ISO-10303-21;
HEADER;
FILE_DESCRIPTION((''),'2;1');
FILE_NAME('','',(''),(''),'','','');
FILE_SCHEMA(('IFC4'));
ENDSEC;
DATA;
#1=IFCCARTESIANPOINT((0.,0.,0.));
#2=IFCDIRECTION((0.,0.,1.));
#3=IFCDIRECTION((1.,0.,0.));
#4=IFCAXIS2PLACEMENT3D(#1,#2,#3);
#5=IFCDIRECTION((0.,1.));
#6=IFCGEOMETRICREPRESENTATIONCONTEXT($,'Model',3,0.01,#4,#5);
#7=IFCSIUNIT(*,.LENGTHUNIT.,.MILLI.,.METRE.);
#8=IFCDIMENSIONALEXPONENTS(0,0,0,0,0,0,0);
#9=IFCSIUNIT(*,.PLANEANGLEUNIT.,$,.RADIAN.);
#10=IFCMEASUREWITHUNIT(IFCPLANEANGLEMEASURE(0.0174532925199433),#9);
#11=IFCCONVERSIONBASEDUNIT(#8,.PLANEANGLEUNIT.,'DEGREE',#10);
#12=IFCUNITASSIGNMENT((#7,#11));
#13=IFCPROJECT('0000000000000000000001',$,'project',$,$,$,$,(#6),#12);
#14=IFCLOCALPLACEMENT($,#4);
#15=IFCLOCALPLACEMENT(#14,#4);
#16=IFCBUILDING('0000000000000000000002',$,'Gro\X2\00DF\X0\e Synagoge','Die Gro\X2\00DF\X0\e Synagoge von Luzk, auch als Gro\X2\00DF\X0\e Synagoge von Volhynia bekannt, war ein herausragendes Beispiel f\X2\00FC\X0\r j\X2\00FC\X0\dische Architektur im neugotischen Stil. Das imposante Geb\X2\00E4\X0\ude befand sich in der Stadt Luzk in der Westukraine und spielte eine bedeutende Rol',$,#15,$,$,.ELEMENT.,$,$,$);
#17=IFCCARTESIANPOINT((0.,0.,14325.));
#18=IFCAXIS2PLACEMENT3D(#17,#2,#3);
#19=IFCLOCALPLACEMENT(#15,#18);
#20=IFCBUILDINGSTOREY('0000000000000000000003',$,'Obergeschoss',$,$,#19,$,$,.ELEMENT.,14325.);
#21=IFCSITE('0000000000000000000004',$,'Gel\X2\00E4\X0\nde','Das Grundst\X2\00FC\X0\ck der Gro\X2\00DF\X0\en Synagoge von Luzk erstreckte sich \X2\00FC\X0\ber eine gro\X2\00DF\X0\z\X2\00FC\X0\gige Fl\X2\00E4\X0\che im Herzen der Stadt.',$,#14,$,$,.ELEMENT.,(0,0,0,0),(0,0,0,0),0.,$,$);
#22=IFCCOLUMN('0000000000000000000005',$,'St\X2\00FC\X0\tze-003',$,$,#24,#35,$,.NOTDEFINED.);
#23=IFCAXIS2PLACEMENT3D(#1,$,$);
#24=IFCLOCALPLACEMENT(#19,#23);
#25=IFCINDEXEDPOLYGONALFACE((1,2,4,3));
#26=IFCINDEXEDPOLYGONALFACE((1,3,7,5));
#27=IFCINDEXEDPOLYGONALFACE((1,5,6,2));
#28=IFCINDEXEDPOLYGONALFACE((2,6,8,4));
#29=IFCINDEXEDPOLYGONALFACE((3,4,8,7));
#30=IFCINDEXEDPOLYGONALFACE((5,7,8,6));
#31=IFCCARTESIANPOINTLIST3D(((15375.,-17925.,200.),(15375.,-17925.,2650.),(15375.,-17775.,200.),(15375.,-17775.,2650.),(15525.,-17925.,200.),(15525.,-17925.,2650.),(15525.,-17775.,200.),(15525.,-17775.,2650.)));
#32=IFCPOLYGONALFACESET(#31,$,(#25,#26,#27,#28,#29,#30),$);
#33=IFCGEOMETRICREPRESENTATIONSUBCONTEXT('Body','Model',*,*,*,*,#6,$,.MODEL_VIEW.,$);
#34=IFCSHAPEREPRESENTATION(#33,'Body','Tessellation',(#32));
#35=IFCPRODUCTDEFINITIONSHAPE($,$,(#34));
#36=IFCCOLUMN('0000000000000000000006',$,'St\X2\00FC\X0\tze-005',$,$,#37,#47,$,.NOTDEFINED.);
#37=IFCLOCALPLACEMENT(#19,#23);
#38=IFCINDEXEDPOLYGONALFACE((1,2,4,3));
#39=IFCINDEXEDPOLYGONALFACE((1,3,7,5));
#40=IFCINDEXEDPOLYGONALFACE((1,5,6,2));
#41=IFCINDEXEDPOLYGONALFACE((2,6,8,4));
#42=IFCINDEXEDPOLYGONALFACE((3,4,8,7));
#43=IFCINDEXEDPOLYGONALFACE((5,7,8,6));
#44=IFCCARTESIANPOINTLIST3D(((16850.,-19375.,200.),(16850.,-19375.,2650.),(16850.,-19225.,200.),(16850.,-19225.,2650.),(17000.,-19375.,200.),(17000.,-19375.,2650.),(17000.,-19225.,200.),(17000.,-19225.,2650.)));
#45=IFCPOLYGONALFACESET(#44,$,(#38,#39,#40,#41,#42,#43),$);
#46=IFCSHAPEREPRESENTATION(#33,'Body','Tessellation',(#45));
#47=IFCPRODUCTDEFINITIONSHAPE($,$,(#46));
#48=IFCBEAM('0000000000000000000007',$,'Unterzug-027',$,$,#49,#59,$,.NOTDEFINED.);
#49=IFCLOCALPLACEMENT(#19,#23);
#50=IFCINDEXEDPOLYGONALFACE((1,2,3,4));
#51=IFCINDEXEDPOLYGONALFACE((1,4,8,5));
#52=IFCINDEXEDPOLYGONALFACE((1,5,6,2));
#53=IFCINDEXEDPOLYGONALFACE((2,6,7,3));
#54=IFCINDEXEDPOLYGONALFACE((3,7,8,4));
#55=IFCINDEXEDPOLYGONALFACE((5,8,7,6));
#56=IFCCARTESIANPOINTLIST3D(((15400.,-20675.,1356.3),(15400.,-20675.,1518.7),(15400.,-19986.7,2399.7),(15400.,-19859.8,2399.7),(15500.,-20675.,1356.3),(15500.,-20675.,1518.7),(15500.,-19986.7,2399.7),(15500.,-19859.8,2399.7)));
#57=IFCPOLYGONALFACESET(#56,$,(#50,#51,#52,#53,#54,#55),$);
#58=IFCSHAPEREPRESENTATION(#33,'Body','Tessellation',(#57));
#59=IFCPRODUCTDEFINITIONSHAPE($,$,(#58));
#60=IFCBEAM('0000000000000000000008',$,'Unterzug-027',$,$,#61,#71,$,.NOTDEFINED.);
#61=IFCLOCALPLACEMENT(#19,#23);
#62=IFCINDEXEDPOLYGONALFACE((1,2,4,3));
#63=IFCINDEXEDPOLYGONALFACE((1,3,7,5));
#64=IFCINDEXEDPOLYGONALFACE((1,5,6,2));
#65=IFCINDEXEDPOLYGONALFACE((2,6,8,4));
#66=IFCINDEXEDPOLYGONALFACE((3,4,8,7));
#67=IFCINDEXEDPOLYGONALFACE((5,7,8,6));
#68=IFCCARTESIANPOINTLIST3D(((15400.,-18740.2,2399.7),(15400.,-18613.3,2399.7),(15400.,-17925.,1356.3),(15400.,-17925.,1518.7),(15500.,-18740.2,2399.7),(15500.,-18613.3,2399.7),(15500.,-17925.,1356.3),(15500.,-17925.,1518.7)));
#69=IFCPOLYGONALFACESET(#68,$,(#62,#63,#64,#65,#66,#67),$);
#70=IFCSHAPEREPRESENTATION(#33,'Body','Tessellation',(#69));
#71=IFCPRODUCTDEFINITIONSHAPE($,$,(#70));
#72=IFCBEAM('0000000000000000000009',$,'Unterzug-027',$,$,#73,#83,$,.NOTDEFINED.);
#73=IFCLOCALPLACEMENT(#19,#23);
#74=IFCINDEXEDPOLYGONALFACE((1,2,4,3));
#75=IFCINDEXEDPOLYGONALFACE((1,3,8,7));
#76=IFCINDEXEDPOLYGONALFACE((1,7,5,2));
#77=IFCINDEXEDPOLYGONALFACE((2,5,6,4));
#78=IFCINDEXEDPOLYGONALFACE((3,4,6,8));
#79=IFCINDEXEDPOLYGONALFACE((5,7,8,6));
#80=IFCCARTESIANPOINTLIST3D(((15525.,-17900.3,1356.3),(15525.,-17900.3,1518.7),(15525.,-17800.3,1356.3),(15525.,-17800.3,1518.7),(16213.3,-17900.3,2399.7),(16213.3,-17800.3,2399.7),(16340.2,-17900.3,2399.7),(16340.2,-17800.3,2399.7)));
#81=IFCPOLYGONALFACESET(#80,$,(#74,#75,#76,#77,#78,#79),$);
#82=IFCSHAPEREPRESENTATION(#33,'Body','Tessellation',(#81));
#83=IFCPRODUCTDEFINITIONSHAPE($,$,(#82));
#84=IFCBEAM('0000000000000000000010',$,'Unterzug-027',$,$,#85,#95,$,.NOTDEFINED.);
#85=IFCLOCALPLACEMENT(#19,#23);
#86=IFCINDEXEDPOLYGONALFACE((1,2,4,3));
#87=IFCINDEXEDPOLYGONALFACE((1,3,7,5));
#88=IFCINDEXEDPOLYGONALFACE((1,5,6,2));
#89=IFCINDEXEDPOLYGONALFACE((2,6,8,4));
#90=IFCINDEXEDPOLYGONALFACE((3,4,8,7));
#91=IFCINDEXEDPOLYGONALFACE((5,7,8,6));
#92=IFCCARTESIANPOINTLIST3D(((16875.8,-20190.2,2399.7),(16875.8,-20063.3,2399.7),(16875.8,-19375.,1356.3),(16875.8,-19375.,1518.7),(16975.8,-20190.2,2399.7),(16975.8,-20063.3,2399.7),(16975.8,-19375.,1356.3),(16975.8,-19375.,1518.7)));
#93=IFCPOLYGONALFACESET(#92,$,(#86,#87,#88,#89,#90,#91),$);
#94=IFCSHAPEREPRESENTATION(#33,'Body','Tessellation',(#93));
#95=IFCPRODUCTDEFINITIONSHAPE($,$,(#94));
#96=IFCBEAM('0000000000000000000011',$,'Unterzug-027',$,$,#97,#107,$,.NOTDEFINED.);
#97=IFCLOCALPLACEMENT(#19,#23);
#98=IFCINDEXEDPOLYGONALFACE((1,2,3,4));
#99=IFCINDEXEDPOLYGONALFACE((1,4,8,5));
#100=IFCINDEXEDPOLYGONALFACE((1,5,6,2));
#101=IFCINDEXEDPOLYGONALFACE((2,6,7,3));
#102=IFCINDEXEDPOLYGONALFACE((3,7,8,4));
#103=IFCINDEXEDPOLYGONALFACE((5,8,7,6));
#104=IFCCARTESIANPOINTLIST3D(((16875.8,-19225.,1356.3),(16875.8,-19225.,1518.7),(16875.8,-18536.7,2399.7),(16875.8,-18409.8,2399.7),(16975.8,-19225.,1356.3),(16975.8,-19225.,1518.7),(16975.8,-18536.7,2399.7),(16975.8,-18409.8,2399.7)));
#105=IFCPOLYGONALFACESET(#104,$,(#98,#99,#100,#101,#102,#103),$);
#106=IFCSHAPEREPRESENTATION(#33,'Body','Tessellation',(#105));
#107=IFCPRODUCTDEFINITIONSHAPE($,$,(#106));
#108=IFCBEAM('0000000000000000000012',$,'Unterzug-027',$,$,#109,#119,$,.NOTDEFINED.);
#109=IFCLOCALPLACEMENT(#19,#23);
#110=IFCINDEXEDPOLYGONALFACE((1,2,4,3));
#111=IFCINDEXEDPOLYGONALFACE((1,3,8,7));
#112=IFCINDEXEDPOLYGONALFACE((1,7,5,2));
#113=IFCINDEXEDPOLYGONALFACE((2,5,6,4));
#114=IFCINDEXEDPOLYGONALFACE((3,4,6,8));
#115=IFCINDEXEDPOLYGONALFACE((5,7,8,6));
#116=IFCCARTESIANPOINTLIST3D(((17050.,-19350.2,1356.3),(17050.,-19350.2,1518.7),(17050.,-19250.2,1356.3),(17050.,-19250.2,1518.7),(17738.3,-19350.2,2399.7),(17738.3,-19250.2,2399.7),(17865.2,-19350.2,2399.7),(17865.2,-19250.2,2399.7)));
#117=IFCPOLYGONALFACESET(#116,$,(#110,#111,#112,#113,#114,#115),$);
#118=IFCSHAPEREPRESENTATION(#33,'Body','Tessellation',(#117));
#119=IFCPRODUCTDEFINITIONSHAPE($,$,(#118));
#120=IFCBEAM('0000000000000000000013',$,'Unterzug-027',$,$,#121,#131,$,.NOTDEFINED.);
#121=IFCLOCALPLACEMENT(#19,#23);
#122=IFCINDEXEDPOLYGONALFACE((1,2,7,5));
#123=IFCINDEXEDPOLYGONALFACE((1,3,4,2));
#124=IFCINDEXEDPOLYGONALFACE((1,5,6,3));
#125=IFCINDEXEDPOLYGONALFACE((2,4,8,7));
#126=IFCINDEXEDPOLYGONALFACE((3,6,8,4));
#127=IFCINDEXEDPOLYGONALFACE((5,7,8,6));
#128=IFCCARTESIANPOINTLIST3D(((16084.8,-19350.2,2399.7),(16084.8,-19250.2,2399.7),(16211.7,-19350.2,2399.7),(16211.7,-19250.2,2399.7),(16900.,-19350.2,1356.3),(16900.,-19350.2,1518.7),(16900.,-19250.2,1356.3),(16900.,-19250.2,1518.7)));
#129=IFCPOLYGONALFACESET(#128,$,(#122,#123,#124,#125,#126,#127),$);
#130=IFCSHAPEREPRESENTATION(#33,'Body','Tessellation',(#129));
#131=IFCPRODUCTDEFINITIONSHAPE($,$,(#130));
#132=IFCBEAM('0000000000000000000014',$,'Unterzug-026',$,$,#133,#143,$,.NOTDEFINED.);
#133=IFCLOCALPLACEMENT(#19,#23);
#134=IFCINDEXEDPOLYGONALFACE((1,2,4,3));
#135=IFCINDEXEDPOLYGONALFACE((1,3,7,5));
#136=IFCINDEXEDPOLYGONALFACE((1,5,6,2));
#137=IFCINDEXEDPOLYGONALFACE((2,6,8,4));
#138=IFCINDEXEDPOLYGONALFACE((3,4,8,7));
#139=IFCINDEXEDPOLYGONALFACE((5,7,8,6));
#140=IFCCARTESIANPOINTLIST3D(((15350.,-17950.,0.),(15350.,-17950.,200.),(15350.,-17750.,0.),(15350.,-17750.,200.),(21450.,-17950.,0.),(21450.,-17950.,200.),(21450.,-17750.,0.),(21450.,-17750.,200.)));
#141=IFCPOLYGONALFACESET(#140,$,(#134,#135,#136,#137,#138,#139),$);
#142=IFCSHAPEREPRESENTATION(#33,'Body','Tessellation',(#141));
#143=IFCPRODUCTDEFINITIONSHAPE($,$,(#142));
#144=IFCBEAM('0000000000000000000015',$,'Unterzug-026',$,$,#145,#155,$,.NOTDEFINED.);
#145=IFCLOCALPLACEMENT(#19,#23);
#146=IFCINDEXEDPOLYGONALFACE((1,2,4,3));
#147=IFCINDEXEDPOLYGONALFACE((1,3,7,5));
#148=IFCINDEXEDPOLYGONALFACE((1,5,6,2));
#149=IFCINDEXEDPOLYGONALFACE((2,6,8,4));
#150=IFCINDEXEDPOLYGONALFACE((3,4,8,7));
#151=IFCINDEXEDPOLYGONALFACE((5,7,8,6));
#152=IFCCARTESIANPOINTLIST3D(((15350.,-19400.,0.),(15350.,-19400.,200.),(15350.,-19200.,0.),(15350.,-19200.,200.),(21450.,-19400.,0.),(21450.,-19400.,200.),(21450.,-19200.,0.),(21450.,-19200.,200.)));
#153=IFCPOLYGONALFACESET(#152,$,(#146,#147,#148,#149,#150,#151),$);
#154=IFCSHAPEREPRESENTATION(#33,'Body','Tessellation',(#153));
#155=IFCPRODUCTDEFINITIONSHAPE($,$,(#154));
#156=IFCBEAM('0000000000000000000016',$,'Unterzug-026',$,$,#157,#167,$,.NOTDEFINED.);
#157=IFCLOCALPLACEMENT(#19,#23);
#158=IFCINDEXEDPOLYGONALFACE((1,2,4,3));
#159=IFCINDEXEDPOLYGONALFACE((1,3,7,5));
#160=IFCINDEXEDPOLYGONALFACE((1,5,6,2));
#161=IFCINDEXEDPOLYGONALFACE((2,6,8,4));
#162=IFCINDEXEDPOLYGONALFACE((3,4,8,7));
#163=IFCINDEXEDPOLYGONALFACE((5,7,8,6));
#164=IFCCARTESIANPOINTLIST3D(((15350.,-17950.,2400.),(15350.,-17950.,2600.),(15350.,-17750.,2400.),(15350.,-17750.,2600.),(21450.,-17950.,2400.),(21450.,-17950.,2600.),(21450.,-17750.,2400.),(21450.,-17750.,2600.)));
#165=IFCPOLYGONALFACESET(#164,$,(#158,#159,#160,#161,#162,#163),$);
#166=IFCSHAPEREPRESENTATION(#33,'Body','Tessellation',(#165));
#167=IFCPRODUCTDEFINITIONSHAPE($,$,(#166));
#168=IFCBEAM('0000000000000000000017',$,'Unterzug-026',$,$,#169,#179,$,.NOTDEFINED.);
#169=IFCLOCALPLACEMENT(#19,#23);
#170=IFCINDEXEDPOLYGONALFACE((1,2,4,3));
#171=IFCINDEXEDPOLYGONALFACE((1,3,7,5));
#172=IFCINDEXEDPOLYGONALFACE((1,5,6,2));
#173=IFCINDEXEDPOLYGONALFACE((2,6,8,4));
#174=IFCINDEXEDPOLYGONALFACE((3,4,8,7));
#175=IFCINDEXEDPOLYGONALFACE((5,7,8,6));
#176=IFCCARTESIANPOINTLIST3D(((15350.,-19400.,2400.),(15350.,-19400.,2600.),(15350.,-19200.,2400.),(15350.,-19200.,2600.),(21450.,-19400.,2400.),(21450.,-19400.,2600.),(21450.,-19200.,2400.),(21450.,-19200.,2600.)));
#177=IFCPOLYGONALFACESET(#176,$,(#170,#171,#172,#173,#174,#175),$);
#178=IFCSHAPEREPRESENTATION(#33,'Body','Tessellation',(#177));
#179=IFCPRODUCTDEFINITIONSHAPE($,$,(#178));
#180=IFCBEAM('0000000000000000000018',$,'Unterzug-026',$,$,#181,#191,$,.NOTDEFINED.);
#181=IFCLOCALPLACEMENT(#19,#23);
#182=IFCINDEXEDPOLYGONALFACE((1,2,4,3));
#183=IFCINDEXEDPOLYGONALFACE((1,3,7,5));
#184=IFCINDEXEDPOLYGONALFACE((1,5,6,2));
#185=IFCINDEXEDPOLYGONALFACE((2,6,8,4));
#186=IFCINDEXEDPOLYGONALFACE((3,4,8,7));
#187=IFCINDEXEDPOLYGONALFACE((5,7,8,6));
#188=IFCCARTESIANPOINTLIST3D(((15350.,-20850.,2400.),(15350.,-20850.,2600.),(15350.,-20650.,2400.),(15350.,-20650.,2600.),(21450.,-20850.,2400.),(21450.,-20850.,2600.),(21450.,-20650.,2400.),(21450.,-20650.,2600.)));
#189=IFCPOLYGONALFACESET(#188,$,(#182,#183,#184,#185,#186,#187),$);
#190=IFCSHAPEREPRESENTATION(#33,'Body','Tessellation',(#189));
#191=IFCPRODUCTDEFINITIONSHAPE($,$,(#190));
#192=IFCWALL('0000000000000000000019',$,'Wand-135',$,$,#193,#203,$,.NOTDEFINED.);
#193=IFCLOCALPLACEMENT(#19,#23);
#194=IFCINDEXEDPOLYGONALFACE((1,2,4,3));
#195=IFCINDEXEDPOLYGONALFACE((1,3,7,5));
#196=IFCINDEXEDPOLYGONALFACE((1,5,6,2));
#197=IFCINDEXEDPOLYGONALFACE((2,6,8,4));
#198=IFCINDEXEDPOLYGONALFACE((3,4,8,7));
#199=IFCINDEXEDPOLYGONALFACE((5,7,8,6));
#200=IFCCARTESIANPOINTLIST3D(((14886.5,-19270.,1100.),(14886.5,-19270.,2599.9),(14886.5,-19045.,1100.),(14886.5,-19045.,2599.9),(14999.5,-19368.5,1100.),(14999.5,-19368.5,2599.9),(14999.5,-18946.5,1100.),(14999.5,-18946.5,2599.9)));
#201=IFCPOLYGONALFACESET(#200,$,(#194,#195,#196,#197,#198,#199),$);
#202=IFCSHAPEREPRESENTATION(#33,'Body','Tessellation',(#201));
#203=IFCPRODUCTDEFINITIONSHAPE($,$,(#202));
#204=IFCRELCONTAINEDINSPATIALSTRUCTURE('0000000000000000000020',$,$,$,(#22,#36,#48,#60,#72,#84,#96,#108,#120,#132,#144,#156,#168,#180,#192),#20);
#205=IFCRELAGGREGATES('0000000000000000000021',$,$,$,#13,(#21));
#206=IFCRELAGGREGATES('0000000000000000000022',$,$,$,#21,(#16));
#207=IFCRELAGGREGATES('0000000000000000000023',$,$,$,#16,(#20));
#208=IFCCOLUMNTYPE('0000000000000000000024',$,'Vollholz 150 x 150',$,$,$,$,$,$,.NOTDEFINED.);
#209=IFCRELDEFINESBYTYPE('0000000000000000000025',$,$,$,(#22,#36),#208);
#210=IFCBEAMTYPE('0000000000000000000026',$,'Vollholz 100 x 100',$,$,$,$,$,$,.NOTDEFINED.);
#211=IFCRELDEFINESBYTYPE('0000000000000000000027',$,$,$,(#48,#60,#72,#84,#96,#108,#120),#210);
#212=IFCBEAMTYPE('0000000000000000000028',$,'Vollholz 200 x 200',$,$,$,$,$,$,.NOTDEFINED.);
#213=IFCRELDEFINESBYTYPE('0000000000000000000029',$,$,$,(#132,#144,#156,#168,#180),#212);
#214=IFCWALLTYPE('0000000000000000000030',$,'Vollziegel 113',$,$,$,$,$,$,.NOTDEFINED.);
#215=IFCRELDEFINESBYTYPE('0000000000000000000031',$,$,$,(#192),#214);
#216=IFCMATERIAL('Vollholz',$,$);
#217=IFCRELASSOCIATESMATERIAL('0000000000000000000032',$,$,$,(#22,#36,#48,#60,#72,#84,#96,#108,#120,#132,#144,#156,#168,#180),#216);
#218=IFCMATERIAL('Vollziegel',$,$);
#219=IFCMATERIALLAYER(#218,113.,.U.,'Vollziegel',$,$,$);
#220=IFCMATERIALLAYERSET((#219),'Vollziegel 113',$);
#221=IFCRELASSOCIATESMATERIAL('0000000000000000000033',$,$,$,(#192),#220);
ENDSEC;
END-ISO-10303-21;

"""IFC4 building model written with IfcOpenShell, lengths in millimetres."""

from ifc_helpers import new_model, entity, si_unit, converted_unit, direction, frame, frame_2d, origin_with_axes, origin_2d_with_axis, place, context, subcontext, project, spatial, line, indexed_curve, rectangle, outline, extrude, clip, halfspace, material, layer, layer_set, layer_usage, type_object, element, save


model = new_model("IFC4")

# Units and contexts
model_context = context("Model", 3, precision=0.01, world=origin_with_axes(), true_north=direction((0.0, 1.0)))
body_context = subcontext(model_context, "Body", "Model", "MODEL_VIEW")
ifc_project = project(units=[si_unit("LENGTHUNIT", "METRE", prefix="MILLI"), converted_unit("PLANEANGLEUNIT", "DEGREE", entity("IfcPlaneAngleMeasure", 0.0174532925199433), si_unit("PLANEANGLEUNIT", "RADIAN"), dimensions=[0, 0, 0, 0, 0, 0, 0])], contexts=[model_context])

# Site, building, storey
site_placement = place(None, origin_with_axes())
site = spatial("IfcSite", under=ifc_project, at=site_placement, Name="Gelände", Description="Das Grundstück der Großen Synagoge von Luzk erstreckte sich über eine großzügige Fläche im Herzen der Stadt.", CompositionType="ELEMENT", RefLatitude=(0, 0, 0, 0), RefLongitude=(0, 0, 0, 0), RefElevation=0.0)
building_placement = place(site_placement, origin_with_axes())
building = spatial("IfcBuilding", under=site, at=building_placement, Name="Große Synagoge", Description="Die Große Synagoge von Luzk, auch als Große Synagoge von Volhynia bekannt, war ein herausragendes Beispiel für jüdische Architektur im neugotischen Stil. Das imposante Gebäude befand sich in der Stadt Luzk in der Westukraine und spielte eine bedeutende Rol", CompositionType="ELEMENT")
storey_placement = place(building_placement, frame((0.0, 0.0, 14325.0), z_axis=(0.0, 0.0, 1.0), x_axis=(1.0, 0.0, 0.0)))
storey = spatial("IfcBuildingStorey", under=building, at=storey_placement, Name="Obergeschoss", CompositionType="ELEMENT", Elevation=14325.0)

# Columns
ifc_material_1 = material(Name="Vollholz")
column_type = type_object("IfcColumnType", Name="Vollholz 150 x 150", PredefinedType="NOTDEFINED")
for number, where, z_axis, x_axis, name in (
    (1, (15450.0, -17850.0, 200.0), (0.0, 0.0, 1.0), (1.0, 0.0, 0.0), "Stütze-003"),
    (2, (16925.0, -19300.0, 200.0), (0.0, 0.0, 1.0), (1.0, 0.0, 0.0), "Stütze-005"),
):
    element("IfcColumn", number, at=place(storey_placement, frame(where, z_axis=z_axis, x_axis=x_axis)), inside=storey, type_object=column_type, material=ifc_material_1, Name=name, PredefinedType="NOTDEFINED", context=body_context, shape_type="SweptSolid", body=[
        extrude(rectangle(XDim=150.0, YDim=150.0, at=origin_2d_with_axis()), origin_with_axes(), (0.0, 0.0, 1.0), 2450.0),
    ])

# Beams
beam_type_1 = type_object("IfcBeamType", Name="Vollholz 100 x 100", PredefinedType="NOTDEFINED")
for number, where, z_axis, x_axis, name in (
    (3, (15450.0, -20675.0, 1518.7), (0.0, 0.0, 1.0), (1.0, 0.0, 0.0), "Unterzug-027"),
    (4, (15450.0, -17925.0, 1518.7), (0.0, 0.0, 1.0), (-1.0, 0.0, 0.0), "Unterzug-027"),
):
    element("IfcBeam", number, at=place(storey_placement, frame(where, z_axis=z_axis, x_axis=x_axis)), inside=storey, type_object=beam_type_1, material=ifc_material_1, Name=name, PredefinedType="NOTDEFINED", context=body_context, shape_type="Clipping", body=[
        clip(clip(extrude(rectangle(XDim=100.0, YDim=100.0, at=frame_2d((-50.0, 0.0), x_axis=(1.0, 0.0))), frame((0.0, -111.4, -142.6), z_axis=(0.0, 0.615661, 0.788011), x_axis=(0.0, -0.788011, 0.615661)), (0.0, 0.0, 1.0), 1409.5), halfspace(frame((0.0, 0.0, 0.0), z_axis=(0.0, 1.0, 0.0), x_axis=(0.0, 0.0, 1.0)), True)), halfspace(frame((0.0, 0.0, 881.0), z_axis=(0.0, 0.0, -1.0), x_axis=(0.0, 1.0, 0.0)), True)),
    ])
for number, where, z_axis, x_axis, name in (
    (5, (15525.0, -17850.3, 1518.7), (0.0, 0.0, 1.0), (0.0, -1.0, 0.0), "Unterzug-027"),
    (6, (16925.8, -19375.0, 1518.7), (0.0, 0.0, 1.0), (-1.0, 0.0, 0.0), "Unterzug-027"),
    (7, (16925.8, -19225.0, 1518.7), (0.0, 0.0, 1.0), (1.0, 0.0, 0.0), "Unterzug-027"),
):
    element("IfcBeam", number, at=place(storey_placement, frame(where, z_axis=z_axis, x_axis=x_axis)), inside=storey, type_object=beam_type_1, material=ifc_material_1, Name=name, PredefinedType="NOTDEFINED", context=body_context, shape_type="Clipping", body=[
        clip(clip(extrude(rectangle(XDim=100.0, YDim=100.0, at=frame_2d((-50.0, 0.0), x_axis=(1.0, 0.0))), frame((0.0, -111.4, -142.6), z_axis=(0.0, 0.615661, 0.788011), x_axis=(0.0, -0.788011, 0.615661)), (0.0, 0.0, 1.0), 1409.5), halfspace(frame((0.0, 0.0, 0.0), z_axis=(0.0, 1.0, 0.0), x_axis=(0.0, 0.0, 1.0)), True)), halfspace(frame((0.0, 0.0, 881.0), z_axis=(0.0, 0.0, -1.0), x_axis=(0.0, 1.0, 0.0)), True)),
    ])
for number, where, z_axis, x_axis, name in (
    (8, (17050.0, -19300.2, 1518.7), (0.0, 0.0, 1.0), (0.0, -1.0, 0.0), "Unterzug-027"),
    (9, (16900.0, -19300.2, 1518.7), (0.0, 0.0, 1.0), (0.0, 1.0, 0.0), "Unterzug-027"),
):
    element("IfcBeam", number, at=place(storey_placement, frame(where, z_axis=z_axis, x_axis=x_axis)), inside=storey, type_object=beam_type_1, material=ifc_material_1, Name=name, PredefinedType="NOTDEFINED", context=body_context, shape_type="Clipping", body=[
        clip(clip(extrude(rectangle(XDim=100.0, YDim=100.0, at=frame_2d((-50.0, 0.0), x_axis=(1.0, 0.0))), frame((0.0, -111.4, -142.6), z_axis=(0.0, 0.615661, 0.788011), x_axis=(0.0, -0.788011, 0.615661)), (0.0, 0.0, 1.0), 1409.5), halfspace(frame((0.0, 0.0, 0.0), z_axis=(0.0, 1.0, 0.0), x_axis=(0.0, 0.0, 1.0)), True)), halfspace(frame((0.0, 0.0, 881.0), z_axis=(0.0, 0.0, -1.0), x_axis=(0.0, 1.0, 0.0)), True)),
    ])
beam_type_2 = type_object("IfcBeamType", Name="Vollholz 200 x 200", PredefinedType="NOTDEFINED")
for number, where, z_axis, x_axis, name in (
    (10, (15350.0, -17850.0, 200.0), (0.0, 0.0, 1.0), (0.0, -1.0, 0.0), "Unterzug-026"),
    (11, (15350.0, -19300.0, 200.0), (0.0, 0.0, 1.0), (0.0, -1.0, 0.0), "Unterzug-026"),
    (12, (15350.0, -17850.0, 2600.0), (0.0, 0.0, 1.0), (0.0, -1.0, 0.0), "Unterzug-026"),
    (13, (15350.0, -19300.0, 2600.0), (0.0, 0.0, 1.0), (0.0, -1.0, 0.0), "Unterzug-026"),
    (14, (15350.0, -20750.0, 2600.0), (0.0, 0.0, 1.0), (0.0, -1.0, 0.0), "Unterzug-026"),
):
    element("IfcBeam", number, at=place(storey_placement, frame(where, z_axis=z_axis, x_axis=x_axis)), inside=storey, type_object=beam_type_2, material=ifc_material_1, Name=name, PredefinedType="NOTDEFINED", context=body_context, shape_type="SweptSolid", body=[
        extrude(rectangle(XDim=200.0, YDim=200.0, at=frame_2d((-100.0, 0.0), x_axis=(1.0, 0.0))), frame((0.0, 0.0, 0.0), z_axis=(0.0, 1.0, 0.0), x_axis=(0.0, 0.0, 1.0)), (0.0, 0.0, 1.0), 6100.0),
    ])

# Wall
ifc_material_2 = material(Name="Vollziegel")
ifc_layer = layer(ifc_material_2, 113.0, ventilated="UNKNOWN", Name="Vollziegel")
ifc_layer_set = layer_set([ifc_layer], Name="Vollziegel 113")
ifc_layer_usage = layer_usage(ifc_layer_set, "AXIS2", "NEGATIVE", 113.0)
wall_type_1 = type_object("IfcWallType", Name="Vollziegel 113", PredefinedType="NOTDEFINED")
wall_1_placement = place(storey_placement, frame((14999.5, -19270.0, 1100.0), z_axis=(0.0, 0.0, 1.0), x_axis=(0.0, 1.0, 0.0)))
element("IfcWall", 15, at=wall_1_placement, inside=storey, type_object=wall_type_1, material=ifc_layer_usage, Name="Wand-135", PredefinedType="NOTDEFINED", context=body_context, shape_type="SweptSolid", body=[
    extrude(outline(indexed_curve([(-98.5, 0.0), (323.5, 0.0), (225.0, 113.0), (0.0, 113.0)], segments=[line(1, 2, 3, 4, 1)])), origin_with_axes(), (0.0, 0.0, 1.0), 1499.9),
])

save(model, "model.ifc")
